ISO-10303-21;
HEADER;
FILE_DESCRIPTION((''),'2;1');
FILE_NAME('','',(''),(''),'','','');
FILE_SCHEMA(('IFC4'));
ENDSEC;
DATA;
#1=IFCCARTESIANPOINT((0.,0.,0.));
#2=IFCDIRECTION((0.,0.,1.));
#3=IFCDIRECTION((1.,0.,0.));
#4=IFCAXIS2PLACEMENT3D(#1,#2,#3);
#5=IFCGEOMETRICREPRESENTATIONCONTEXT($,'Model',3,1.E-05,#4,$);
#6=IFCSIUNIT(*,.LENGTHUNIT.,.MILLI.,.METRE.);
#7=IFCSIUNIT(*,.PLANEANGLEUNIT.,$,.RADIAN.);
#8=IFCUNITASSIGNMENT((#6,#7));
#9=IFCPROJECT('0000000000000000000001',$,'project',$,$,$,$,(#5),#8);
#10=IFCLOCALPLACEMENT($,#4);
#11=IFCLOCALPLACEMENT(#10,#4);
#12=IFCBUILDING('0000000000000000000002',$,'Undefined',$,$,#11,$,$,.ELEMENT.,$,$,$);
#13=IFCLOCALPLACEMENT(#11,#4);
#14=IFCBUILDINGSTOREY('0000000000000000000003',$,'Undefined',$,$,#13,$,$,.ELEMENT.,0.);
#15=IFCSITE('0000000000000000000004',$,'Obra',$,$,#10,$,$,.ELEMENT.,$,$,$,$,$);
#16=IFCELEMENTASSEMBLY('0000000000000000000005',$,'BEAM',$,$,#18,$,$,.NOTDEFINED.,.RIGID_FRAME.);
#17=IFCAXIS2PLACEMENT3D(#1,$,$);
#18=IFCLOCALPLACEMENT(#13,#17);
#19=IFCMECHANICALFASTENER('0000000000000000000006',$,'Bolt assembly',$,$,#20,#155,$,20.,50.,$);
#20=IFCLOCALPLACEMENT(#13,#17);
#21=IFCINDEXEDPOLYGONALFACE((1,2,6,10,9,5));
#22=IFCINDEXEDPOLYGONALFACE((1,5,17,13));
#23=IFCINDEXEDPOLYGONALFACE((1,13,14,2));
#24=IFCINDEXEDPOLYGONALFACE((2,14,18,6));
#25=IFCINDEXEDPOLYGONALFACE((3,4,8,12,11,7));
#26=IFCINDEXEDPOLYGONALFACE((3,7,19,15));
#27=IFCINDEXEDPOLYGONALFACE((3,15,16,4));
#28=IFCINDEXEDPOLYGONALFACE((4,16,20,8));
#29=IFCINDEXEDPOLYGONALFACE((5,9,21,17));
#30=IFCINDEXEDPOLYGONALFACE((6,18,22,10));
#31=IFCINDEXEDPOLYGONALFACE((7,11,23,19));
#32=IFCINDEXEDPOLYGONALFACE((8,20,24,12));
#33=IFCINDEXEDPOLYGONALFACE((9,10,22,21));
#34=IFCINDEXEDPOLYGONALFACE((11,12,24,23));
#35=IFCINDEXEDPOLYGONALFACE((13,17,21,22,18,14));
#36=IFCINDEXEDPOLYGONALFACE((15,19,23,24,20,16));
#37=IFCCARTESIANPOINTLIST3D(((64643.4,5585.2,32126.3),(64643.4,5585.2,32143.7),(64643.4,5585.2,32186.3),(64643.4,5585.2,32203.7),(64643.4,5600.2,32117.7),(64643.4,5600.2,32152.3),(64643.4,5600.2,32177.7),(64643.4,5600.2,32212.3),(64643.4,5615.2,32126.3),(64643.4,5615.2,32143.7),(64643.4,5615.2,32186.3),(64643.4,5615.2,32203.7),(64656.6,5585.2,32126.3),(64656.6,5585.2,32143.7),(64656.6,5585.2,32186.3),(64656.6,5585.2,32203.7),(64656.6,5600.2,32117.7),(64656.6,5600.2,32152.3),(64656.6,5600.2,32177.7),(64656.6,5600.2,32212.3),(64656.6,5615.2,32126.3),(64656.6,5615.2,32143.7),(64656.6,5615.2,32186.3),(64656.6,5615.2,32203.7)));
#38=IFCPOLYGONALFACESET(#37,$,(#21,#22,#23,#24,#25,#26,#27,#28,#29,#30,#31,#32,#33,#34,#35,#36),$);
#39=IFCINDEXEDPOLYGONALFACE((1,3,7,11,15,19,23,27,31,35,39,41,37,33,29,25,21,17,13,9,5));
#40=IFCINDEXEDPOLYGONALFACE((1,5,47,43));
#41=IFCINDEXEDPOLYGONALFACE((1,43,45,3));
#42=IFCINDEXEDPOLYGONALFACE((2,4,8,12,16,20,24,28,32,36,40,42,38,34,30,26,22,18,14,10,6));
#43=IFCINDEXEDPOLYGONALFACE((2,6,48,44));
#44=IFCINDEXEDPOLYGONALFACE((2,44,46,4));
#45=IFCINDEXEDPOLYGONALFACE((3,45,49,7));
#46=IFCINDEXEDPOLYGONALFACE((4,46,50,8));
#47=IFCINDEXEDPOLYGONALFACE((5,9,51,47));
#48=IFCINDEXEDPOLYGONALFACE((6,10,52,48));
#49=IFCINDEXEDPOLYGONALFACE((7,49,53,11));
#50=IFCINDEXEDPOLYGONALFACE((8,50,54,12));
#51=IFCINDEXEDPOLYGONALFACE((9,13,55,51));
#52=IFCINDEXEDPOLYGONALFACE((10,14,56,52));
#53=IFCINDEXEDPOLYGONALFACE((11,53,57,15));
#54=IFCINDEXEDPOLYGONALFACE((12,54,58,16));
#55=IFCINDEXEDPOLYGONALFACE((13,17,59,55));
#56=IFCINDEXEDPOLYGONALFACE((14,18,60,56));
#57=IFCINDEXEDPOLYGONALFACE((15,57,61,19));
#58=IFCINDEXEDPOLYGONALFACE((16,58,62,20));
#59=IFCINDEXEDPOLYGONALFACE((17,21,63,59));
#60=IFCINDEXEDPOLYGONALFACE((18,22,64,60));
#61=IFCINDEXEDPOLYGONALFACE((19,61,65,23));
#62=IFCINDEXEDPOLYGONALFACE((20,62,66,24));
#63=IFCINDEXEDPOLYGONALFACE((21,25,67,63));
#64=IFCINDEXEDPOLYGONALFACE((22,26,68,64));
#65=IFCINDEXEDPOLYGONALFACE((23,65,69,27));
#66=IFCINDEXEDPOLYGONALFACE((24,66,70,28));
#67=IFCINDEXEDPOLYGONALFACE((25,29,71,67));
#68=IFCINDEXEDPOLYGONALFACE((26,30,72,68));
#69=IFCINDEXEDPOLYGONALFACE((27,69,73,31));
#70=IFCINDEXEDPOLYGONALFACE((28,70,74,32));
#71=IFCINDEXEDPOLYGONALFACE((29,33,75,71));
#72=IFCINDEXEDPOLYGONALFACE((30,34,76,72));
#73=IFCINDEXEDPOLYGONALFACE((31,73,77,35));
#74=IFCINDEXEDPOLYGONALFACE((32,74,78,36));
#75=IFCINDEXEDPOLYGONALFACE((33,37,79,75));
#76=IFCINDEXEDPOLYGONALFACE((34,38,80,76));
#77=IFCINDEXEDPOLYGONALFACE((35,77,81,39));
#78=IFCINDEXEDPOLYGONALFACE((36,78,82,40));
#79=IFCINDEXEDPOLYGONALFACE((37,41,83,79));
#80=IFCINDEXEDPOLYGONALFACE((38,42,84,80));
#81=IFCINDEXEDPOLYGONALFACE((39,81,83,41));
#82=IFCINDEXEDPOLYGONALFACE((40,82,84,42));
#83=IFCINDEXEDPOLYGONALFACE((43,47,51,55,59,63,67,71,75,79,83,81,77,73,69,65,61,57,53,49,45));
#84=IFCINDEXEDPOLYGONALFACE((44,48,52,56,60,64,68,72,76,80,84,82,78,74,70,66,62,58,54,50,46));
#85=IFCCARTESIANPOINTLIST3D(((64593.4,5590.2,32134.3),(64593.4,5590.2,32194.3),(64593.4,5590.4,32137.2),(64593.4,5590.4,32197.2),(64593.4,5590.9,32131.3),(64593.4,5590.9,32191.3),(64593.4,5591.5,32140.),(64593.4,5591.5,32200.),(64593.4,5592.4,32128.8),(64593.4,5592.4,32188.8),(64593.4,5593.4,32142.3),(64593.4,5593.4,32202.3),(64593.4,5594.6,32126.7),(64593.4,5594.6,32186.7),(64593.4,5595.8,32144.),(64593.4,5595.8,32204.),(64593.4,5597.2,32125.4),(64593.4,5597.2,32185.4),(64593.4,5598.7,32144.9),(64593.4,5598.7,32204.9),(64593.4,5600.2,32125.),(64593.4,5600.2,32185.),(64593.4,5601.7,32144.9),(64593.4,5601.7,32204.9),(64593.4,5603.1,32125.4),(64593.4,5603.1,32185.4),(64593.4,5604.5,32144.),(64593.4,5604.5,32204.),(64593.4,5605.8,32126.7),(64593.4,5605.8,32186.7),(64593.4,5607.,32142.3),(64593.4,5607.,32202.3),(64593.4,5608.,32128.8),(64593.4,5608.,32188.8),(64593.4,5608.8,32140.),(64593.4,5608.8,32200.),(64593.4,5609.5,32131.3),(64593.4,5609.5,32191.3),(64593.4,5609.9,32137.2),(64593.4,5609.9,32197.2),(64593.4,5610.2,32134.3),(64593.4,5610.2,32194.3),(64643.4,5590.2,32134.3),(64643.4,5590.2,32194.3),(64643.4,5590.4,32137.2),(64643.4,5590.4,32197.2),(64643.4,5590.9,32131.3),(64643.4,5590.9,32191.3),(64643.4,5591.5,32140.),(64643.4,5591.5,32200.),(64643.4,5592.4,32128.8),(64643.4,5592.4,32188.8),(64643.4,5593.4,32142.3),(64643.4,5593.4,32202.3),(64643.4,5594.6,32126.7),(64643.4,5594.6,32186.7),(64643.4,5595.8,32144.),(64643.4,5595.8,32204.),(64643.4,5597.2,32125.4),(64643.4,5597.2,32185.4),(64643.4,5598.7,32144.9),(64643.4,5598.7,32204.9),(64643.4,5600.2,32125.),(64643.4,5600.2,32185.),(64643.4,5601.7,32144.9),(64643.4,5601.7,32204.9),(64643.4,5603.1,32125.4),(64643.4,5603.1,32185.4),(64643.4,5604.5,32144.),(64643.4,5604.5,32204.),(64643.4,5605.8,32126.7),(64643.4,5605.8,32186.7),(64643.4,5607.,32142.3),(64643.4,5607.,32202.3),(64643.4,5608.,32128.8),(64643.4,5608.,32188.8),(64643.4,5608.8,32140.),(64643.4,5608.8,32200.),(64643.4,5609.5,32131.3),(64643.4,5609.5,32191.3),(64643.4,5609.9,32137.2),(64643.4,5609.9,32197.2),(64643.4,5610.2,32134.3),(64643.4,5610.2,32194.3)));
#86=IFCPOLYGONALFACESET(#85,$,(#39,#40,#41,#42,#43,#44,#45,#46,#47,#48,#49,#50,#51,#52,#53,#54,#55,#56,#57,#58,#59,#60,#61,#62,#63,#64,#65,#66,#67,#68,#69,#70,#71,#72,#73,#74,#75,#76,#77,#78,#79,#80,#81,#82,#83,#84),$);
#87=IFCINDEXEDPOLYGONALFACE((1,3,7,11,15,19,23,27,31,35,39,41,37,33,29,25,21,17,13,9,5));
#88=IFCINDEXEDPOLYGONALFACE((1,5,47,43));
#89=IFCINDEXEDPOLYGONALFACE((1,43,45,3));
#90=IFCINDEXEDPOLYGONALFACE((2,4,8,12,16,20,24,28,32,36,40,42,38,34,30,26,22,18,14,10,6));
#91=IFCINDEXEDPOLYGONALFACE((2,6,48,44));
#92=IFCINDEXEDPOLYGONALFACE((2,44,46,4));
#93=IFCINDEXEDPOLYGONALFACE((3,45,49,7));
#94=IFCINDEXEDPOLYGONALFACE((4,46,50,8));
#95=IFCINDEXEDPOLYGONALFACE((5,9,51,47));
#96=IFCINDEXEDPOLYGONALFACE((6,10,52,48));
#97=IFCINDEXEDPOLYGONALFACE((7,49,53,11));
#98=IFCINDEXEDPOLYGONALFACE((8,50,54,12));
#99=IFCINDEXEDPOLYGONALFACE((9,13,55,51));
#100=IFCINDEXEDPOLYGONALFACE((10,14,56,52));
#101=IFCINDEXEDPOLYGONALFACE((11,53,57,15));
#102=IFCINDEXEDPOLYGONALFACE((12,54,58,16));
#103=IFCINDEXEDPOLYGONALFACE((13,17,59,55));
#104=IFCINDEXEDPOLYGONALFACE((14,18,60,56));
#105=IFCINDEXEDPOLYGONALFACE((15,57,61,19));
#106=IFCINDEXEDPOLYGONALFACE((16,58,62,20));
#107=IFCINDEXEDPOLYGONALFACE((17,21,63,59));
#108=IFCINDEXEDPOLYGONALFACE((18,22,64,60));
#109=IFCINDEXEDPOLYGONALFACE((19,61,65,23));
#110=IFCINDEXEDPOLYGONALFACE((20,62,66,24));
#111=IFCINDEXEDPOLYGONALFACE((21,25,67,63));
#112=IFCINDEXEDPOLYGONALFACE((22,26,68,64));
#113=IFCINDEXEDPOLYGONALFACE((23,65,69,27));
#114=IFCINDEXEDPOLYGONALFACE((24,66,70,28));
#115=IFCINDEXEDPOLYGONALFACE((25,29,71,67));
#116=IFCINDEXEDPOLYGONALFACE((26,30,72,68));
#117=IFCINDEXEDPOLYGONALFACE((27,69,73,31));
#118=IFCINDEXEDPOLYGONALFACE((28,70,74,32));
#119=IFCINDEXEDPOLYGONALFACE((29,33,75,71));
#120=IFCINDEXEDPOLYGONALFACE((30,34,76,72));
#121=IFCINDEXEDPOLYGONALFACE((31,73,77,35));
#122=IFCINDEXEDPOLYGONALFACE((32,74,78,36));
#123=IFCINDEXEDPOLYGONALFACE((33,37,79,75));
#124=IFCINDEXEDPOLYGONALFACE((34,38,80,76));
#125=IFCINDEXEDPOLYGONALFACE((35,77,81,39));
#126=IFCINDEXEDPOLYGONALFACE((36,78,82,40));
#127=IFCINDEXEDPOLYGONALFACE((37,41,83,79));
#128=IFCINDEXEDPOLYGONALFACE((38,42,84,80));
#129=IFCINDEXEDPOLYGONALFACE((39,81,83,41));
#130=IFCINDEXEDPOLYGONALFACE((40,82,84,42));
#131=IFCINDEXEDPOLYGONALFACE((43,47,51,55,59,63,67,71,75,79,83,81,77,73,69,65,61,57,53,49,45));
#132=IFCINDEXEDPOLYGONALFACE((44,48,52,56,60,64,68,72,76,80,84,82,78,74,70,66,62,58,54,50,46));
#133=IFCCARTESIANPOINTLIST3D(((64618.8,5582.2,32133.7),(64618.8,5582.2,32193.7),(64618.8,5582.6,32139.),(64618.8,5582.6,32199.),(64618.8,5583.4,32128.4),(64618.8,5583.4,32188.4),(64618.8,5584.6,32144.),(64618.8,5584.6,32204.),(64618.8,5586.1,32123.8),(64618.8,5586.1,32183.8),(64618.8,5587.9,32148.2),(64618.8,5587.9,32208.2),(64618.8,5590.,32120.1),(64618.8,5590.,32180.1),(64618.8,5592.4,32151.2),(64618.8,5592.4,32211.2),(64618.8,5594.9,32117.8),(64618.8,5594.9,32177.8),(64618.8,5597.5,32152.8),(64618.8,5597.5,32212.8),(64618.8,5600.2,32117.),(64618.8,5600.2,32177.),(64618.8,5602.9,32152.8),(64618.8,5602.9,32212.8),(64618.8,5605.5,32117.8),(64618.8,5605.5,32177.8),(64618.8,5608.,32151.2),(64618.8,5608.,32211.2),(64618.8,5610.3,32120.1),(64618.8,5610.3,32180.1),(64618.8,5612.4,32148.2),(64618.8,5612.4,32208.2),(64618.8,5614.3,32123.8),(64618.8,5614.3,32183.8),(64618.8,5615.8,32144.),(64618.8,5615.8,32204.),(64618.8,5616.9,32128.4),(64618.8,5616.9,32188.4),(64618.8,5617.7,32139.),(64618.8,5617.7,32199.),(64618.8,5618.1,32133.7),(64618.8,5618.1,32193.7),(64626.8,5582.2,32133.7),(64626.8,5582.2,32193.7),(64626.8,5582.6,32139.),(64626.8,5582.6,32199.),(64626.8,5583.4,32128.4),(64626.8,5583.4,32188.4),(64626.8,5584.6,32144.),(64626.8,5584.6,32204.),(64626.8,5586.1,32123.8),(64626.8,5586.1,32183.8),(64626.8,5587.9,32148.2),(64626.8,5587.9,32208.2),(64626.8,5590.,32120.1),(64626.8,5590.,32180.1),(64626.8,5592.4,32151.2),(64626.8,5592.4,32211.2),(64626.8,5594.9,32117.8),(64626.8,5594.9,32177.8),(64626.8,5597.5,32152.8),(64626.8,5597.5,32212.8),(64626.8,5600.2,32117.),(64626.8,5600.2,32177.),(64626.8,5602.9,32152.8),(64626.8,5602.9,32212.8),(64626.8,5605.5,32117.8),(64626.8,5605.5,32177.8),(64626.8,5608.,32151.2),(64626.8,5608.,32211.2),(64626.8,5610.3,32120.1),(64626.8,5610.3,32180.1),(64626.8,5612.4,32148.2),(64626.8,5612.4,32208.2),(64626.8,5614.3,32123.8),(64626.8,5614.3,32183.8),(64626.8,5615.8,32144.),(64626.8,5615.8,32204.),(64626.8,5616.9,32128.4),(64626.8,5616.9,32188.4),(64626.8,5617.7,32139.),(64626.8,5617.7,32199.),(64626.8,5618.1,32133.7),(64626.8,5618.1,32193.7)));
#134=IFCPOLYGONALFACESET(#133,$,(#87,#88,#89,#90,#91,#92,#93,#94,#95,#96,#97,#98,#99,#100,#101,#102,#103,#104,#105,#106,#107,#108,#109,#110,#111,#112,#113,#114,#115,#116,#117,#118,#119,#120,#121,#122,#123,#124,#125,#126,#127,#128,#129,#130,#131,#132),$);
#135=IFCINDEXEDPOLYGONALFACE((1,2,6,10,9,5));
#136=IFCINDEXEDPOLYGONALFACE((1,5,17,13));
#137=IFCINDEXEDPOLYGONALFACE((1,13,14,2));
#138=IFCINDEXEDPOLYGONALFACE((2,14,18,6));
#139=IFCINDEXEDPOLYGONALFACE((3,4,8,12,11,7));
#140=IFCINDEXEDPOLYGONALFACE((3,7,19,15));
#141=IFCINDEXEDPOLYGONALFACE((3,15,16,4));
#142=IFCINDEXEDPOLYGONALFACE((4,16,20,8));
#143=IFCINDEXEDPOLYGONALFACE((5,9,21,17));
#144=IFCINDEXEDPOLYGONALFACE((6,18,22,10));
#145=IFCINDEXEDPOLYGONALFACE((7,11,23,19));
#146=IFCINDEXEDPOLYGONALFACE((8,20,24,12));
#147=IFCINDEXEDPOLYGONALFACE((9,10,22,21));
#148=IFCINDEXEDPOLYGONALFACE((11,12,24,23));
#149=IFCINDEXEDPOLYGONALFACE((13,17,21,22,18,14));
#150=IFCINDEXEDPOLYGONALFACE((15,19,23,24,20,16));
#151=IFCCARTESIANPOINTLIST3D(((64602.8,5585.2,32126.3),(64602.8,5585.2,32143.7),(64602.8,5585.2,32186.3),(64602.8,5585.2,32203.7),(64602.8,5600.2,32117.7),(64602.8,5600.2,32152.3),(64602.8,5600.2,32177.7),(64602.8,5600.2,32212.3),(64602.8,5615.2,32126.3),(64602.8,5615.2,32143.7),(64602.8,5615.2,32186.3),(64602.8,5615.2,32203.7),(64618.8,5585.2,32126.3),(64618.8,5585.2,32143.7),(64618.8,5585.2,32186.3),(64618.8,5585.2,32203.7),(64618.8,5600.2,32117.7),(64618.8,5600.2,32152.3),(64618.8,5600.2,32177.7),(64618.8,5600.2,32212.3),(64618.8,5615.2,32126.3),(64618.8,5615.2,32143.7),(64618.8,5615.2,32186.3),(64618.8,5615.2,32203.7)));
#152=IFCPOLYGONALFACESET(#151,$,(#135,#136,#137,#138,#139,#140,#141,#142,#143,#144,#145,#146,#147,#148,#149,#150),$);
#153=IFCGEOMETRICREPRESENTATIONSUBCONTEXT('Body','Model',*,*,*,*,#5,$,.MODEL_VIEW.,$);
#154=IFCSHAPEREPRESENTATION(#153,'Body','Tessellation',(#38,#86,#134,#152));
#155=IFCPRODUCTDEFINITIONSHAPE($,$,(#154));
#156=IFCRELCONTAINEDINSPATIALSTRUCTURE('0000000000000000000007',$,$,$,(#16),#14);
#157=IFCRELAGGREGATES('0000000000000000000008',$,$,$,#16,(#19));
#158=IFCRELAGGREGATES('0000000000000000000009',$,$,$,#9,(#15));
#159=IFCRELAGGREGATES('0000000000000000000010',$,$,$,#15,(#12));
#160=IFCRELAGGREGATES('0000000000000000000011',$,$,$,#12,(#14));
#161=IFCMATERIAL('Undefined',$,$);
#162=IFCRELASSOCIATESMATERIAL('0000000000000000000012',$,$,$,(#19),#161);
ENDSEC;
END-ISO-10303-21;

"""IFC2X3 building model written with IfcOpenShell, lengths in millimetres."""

from ifc_helpers import new_model, si_unit, frame, origin_with_axes, origin_2d_with_axis, place, context, subcontext, project, spatial, polyline, circle, outline, extrude, source, transform, mapped, material, element, aggregate, save


model = new_model("IFC2X3")

# Units and contexts
model_context = context("Model", 3, precision=1e-05, world=origin_with_axes())
body_context = subcontext(model_context, "Body", "Model", "MODEL_VIEW")
ifc_project = project(units=[si_unit("LENGTHUNIT", "METRE", prefix="MILLI"), si_unit("PLANEANGLEUNIT", "RADIAN")], contexts=[model_context])

# Site, building, storey
site_placement = place(None, origin_with_axes())
site = spatial("IfcSite", under=ifc_project, at=site_placement, Name="Obra", CompositionType="ELEMENT")
building_placement = place(site_placement, origin_with_axes())
building = spatial("IfcBuilding", under=site, at=building_placement, Name="Undefined", CompositionType="ELEMENT")
storey_placement = place(building_placement, origin_with_axes())
storey = spatial("IfcBuildingStorey", under=building, at=storey_placement, Name="Undefined", CompositionType="ELEMENT", Elevation=0.0)

# Element assembly
assembly_1_placement = place(storey_placement, origin_with_axes())
assembly_1 = element("IfcElementAssembly", 1, at=assembly_1_placement, inside=storey, Name="BEAM", AssemblyPlace="NOTDEFINED", PredefinedType="RIGID_FRAME")

# Mechanical fastener
ifc_material_1 = material(Name="Undefined")
shared_shape_1 = source(origin_with_axes(), body_context, "Body", "SweptSolid", [
    extrude(outline(polyline([(17.3, 0.0), (8.7, 15.0), (-8.7, 15.0), (-17.3, 0.0), (-8.7, -15.0), (8.7, -15.0), (17.3, 0.0)])), frame((0.0, -26.5, 0.0), z_axis=(0.0, 1.0, 0.0), x_axis=(1.0, 0.0, 0.0)), (0.0, 0.0, 1.0), 13.2),
    extrude(circle(Radius=10.0, at=origin_2d_with_axis()), frame((0.0, -13.3, 0.0), z_axis=(0.0, 1.0, 0.0), x_axis=(1.0, 0.0, 0.0)), (0.0, 0.0, 1.0), 50.0),
    extrude(circle(Radius=18.0, at=origin_2d_with_axis()), frame((0.0, 3.3, 0.0), z_axis=(0.0, 1.0, 0.0), x_axis=(1.0, 0.0, 0.0)), (0.0, 0.0, 1.0), 8.0),
    extrude(outline(polyline([(17.3, 0.0), (8.7, 15.0), (-8.7, 15.0), (-17.3, 0.0), (-8.7, -15.0), (8.7, -15.0), (17.3, 0.0)])), frame((0.0, 11.3, 0.0), z_axis=(0.0, 1.0, 0.0), x_axis=(1.0, 0.0, 0.0)), (0.0, 0.0, 1.0), 16.0),
])
mechanical_fastener_1_placement = place(assembly_1_placement, frame((64630.1, 5560.2, 32235.0), z_axis=(0.0, 1.0, 0.0), x_axis=(0.0, 0.0, -1.0)))
mechanical_fastener_1 = element("IfcMechanicalFastener", 2, at=mechanical_fastener_1_placement, material=ifc_material_1, Name="Bolt assembly", NominalDiameter=20.0, NominalLength=50.0, context=body_context, shape_type="MappedRepresentation", body=[
    mapped(shared_shape_1, transform((40.0, 0.0, 40.0))),
    mapped(shared_shape_1, transform((100.0, 0.0, 40.0))),
])
aggregate(assembly_1, [mechanical_fastener_1])

save(model, "model.ifc")
